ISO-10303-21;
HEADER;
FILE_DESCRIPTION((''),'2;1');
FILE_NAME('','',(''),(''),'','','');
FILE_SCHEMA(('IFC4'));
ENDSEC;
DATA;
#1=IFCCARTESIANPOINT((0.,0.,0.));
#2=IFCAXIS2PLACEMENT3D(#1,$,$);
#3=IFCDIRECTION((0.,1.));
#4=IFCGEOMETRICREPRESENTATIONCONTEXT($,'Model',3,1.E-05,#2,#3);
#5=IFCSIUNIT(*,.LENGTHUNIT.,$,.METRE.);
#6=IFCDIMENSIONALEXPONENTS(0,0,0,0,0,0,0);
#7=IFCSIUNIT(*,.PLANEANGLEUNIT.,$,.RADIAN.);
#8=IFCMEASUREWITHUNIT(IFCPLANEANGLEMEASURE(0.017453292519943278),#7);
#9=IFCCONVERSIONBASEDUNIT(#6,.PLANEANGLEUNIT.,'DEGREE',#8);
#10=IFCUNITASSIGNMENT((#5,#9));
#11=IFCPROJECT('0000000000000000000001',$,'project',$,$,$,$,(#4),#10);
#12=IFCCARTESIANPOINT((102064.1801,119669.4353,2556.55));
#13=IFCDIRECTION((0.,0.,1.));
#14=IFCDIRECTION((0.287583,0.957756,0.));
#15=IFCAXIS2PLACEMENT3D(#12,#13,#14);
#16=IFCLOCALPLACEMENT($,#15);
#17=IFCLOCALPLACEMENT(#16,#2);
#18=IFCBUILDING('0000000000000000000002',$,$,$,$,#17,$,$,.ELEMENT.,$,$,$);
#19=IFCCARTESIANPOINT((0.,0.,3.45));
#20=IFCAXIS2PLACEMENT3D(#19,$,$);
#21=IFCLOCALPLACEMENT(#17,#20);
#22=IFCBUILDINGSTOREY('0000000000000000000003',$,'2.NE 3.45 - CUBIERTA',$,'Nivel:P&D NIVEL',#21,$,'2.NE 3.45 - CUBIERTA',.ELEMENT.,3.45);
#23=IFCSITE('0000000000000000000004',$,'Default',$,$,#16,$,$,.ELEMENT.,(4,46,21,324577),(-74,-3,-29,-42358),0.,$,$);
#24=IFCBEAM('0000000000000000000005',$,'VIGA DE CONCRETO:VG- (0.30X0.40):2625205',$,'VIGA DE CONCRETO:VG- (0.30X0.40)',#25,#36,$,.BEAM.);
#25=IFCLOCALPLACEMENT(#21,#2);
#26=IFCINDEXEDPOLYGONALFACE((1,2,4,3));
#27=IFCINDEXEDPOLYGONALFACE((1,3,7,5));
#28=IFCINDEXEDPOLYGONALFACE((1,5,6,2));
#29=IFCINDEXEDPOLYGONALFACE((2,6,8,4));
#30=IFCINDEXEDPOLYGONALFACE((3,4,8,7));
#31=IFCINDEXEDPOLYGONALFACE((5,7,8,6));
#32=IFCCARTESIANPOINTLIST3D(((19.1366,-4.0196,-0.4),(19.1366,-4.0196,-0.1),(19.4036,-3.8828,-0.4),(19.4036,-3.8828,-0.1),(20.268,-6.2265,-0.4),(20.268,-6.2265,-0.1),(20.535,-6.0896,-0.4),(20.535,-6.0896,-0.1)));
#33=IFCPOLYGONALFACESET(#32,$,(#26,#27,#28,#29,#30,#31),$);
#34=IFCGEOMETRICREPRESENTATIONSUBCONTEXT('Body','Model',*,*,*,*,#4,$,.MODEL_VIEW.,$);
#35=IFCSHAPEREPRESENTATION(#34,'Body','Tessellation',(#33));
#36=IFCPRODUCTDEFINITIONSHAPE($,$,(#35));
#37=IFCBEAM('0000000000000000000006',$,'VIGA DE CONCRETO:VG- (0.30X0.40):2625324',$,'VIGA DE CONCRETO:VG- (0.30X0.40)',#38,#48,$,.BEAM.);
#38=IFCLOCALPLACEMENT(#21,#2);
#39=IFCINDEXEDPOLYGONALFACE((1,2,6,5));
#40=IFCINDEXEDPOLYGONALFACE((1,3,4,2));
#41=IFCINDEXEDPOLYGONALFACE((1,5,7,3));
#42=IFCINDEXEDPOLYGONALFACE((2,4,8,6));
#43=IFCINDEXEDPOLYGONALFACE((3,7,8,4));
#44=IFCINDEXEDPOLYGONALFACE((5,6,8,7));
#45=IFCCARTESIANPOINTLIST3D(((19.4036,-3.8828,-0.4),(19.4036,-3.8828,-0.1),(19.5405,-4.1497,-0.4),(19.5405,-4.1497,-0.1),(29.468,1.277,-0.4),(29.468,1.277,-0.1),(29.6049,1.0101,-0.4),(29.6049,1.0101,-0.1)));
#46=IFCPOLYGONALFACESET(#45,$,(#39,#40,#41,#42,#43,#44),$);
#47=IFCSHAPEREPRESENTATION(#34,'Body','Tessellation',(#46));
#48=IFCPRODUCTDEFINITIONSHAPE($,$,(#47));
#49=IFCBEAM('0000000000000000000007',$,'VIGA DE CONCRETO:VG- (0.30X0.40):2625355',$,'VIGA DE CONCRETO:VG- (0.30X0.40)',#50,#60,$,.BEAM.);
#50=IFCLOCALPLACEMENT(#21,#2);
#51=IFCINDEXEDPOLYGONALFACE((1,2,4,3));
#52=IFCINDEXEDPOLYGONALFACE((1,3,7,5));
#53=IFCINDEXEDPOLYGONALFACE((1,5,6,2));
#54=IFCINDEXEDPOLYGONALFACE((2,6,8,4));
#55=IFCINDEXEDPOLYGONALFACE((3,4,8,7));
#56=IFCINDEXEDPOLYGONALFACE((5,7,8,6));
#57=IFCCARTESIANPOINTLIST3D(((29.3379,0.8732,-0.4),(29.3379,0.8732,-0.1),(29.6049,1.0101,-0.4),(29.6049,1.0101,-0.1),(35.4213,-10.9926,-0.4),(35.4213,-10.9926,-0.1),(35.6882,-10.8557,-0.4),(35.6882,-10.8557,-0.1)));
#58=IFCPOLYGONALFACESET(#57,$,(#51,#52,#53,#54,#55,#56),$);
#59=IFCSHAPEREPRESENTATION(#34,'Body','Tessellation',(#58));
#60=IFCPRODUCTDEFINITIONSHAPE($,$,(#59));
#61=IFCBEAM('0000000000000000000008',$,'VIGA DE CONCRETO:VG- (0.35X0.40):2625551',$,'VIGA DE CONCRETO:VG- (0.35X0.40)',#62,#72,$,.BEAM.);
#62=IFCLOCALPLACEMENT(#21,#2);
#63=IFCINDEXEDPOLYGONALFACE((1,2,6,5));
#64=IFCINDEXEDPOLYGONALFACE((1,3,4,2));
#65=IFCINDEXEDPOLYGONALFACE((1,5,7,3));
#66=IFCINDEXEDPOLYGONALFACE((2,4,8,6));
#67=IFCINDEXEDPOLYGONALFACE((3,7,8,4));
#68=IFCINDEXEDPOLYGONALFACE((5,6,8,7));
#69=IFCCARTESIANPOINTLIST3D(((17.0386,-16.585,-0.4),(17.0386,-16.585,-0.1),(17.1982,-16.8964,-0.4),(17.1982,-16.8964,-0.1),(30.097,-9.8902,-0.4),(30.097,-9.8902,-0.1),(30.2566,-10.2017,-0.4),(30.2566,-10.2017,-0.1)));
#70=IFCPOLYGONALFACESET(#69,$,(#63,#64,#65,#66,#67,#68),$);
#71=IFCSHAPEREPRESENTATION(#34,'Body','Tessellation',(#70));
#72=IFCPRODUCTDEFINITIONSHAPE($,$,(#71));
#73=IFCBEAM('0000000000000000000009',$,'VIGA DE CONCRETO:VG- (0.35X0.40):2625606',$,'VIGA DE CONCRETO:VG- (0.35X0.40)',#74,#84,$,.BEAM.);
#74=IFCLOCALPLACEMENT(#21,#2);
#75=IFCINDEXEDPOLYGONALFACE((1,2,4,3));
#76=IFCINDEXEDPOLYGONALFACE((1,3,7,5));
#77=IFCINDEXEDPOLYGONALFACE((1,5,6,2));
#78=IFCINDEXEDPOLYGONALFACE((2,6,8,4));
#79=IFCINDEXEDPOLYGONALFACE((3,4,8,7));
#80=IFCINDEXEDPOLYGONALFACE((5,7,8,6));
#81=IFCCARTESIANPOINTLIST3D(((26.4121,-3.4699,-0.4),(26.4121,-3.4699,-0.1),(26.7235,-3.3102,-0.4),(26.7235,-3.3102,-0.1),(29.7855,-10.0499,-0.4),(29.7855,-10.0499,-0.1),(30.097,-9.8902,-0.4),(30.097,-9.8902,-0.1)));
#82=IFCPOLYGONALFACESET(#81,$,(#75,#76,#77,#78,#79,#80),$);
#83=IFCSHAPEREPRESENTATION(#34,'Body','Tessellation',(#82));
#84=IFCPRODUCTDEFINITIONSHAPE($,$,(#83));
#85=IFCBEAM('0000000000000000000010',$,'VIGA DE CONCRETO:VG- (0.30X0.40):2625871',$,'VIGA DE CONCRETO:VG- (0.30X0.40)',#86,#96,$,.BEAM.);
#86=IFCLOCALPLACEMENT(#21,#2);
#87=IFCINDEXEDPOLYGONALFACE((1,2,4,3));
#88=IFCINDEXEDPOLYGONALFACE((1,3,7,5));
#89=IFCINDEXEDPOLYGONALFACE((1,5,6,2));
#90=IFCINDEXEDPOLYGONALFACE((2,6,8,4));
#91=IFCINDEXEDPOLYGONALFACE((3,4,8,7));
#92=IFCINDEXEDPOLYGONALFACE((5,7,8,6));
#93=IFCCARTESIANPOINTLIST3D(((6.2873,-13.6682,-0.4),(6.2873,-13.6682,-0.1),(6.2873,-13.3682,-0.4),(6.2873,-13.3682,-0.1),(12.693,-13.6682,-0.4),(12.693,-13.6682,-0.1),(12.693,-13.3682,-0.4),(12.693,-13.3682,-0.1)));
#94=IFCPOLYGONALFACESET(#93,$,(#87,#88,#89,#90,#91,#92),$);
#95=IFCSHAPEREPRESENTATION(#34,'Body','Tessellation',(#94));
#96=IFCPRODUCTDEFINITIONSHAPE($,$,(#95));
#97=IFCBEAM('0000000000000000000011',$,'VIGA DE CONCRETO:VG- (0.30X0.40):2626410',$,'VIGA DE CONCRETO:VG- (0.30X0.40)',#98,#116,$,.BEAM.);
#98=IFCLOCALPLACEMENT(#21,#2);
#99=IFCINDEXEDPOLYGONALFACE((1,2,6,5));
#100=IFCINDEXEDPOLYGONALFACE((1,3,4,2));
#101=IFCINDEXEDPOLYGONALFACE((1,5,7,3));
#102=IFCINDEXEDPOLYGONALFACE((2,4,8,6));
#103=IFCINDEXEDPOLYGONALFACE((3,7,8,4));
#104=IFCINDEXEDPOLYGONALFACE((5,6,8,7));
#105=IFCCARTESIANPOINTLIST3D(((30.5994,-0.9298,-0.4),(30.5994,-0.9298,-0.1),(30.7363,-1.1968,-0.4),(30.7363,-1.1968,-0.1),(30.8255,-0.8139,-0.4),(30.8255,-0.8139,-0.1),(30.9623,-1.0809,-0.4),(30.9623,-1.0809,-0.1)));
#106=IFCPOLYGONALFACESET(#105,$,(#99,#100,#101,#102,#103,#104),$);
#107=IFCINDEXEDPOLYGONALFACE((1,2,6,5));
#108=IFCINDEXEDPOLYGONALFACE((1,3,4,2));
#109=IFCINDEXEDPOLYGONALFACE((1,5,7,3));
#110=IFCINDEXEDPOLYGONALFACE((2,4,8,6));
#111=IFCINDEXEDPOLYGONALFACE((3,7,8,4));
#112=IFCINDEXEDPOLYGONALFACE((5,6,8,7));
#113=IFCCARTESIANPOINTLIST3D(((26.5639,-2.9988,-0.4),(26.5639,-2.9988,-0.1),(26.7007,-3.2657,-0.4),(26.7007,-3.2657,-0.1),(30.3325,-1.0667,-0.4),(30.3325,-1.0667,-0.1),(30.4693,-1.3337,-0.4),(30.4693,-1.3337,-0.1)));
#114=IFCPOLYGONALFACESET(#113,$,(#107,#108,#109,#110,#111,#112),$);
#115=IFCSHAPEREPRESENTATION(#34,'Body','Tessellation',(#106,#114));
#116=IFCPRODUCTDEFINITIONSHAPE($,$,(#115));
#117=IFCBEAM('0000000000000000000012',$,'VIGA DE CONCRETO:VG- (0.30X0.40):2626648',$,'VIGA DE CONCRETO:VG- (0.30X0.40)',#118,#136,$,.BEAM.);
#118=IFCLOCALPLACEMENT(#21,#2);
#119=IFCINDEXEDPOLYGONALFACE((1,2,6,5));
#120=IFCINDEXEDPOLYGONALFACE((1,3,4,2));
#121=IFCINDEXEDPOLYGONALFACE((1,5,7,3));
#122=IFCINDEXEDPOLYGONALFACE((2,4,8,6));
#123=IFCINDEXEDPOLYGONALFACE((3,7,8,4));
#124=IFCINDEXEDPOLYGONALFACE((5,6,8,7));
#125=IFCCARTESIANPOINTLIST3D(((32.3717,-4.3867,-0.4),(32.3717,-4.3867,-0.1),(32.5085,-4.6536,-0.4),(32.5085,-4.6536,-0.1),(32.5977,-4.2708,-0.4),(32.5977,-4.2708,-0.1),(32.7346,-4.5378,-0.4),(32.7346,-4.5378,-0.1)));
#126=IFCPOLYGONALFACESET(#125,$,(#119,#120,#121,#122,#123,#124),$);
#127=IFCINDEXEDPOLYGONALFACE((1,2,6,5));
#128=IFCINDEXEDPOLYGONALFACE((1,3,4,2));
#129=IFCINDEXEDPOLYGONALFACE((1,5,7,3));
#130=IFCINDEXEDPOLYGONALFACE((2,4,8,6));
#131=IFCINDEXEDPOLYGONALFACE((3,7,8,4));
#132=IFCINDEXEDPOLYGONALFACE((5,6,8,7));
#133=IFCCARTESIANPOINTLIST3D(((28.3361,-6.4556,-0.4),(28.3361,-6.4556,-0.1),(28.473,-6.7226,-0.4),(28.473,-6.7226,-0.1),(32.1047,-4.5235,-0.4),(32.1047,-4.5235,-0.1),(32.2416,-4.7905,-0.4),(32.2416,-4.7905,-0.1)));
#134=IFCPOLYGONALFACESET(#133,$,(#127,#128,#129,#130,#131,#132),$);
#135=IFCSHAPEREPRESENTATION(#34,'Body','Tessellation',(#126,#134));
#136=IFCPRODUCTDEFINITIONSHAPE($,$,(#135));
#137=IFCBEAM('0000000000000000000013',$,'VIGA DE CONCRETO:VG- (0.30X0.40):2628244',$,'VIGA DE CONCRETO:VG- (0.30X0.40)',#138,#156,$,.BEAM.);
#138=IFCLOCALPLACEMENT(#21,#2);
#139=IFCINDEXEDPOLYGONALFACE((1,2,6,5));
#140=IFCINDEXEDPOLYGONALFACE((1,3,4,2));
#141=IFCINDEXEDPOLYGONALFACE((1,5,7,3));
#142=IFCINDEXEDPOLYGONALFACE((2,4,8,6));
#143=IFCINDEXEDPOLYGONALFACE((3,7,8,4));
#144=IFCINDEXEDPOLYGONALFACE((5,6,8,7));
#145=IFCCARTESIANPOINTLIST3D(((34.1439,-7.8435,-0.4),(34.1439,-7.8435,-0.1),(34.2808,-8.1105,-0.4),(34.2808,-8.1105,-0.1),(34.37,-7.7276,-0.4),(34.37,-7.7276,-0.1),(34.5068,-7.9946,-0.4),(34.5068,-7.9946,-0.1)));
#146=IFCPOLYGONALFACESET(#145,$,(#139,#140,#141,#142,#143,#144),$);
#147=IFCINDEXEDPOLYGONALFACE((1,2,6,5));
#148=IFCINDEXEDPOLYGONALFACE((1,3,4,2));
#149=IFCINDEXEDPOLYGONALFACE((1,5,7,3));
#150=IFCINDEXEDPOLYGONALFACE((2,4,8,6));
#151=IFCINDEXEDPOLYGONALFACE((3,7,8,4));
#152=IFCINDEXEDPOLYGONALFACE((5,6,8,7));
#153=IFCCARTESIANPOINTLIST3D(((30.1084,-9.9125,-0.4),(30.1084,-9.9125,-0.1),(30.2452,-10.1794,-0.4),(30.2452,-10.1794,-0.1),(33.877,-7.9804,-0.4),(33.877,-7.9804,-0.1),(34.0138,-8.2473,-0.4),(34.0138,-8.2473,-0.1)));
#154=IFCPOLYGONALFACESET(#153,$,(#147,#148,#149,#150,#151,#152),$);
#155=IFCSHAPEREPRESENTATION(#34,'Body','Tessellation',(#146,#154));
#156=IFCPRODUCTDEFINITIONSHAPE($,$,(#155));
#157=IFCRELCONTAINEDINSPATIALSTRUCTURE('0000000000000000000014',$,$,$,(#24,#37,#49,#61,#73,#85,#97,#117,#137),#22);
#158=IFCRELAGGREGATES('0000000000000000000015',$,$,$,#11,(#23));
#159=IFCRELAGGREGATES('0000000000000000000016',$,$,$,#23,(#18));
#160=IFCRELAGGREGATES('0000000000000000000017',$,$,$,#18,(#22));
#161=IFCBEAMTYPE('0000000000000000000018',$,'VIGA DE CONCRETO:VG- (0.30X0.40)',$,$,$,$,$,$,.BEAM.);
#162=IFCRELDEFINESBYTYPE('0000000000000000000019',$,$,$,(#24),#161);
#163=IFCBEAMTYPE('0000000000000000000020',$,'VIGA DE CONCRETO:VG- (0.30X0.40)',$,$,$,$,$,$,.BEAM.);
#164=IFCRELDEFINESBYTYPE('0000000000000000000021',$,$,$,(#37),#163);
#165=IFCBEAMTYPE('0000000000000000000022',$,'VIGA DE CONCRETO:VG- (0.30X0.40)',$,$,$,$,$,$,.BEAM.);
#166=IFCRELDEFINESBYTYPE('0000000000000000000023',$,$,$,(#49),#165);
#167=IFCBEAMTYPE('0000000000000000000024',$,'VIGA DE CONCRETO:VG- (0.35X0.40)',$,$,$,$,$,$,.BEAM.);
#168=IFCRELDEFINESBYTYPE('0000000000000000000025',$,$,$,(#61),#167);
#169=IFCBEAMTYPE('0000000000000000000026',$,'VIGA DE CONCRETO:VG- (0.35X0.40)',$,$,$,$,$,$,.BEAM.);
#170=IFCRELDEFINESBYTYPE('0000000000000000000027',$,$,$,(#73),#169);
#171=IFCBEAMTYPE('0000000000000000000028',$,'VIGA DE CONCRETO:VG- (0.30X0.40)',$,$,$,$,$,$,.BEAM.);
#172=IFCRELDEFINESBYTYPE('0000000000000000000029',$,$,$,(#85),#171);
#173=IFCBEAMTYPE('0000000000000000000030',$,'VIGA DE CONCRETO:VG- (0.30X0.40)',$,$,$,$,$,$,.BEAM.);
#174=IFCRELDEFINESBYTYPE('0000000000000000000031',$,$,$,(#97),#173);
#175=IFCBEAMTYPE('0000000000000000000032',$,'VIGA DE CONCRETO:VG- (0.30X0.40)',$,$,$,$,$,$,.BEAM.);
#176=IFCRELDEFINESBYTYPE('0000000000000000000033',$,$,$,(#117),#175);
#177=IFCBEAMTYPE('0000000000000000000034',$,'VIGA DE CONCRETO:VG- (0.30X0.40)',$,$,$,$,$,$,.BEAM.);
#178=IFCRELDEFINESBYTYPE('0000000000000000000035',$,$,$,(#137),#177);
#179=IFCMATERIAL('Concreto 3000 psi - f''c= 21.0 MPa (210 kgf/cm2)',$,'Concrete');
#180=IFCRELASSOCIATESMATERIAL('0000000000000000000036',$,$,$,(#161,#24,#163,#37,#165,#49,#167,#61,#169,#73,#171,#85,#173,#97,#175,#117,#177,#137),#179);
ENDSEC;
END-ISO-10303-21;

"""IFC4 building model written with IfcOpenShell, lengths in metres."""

from ifc_helpers import new_model, entity, si_unit, converted_unit, direction, frame, origin, place, context, subcontext, project, spatial, indexed_curve, outline, extrude, source, transform, mapped, material, type_object, type_shapes, element, save


model = new_model("IFC4")

# Units and contexts
model_context = context("Model", 3, precision=1e-05, world=origin(), true_north=direction((0.0, 1.0)))
body_context = subcontext(model_context, "Body", "Model", "MODEL_VIEW")
ifc_project = project(units=[si_unit("LENGTHUNIT", "METRE"), converted_unit("PLANEANGLEUNIT", "DEGREE", entity("IfcPlaneAngleMeasure", 0.017453292519943278), si_unit("PLANEANGLEUNIT", "RADIAN"), dimensions=[0, 0, 0, 0, 0, 0, 0])], contexts=[model_context])

# Site, building, storey
site_placement = place(None, frame((102064.1801, 119669.4353, 2556.55), z_axis=(0.0, 0.0, 1.0), x_axis=(0.287583, 0.957756, 0.0)))
site = spatial("IfcSite", under=ifc_project, at=site_placement, Name="Default", CompositionType="ELEMENT", RefLatitude=(4, 46, 21, 324577), RefLongitude=(-74, -3, -29, -42358), RefElevation=0.0)
building_placement = place(site_placement, origin())
building = spatial("IfcBuilding", under=site, at=building_placement, CompositionType="ELEMENT")
storey_placement = place(building_placement, frame((0.0, 0.0, 3.45)))
storey = spatial("IfcBuildingStorey", under=building, at=storey_placement, Name="2.NE 3.45 - CUBIERTA", ObjectType="Nivel:P&D NIVEL", LongName="2.NE 3.45 - CUBIERTA", CompositionType="ELEMENT", Elevation=3.45)

# Beams
ifc_material_1 = material(Name="Concreto 3000 psi - f'c= 21.0 MPa (210 kgf/cm2)", Category="Concrete")
beam_type_1 = type_object("IfcBeamType", Name="VIGA DE CONCRETO:VG- (0.30X0.40)", PredefinedType="BEAM", material=ifc_material_1)
shared_shape_1 = source(origin(), body_context, "Body", "SweptSolid", [
    extrude(outline(indexed_curve([(-0.15, -0.15), (0.15, -0.15), (0.15, 0.15), (-0.15, 0.15), (-0.15, -0.15)], self_intersect=False)), frame((20.4015, -6.1581, 3.2), z_axis=(-0.456217, 0.889869, 0.0), x_axis=(0.0, 0.0, 1.0)), (0.0, 0.0, 1.0), 2.48),
])
type_shapes(beam_type_1, [shared_shape_1])
beam_1_placement = place(storey_placement, frame((0.0, 0.0, -3.45)))
element("IfcBeam", 1, at=beam_1_placement, inside=storey, type_object=beam_type_1, material=ifc_material_1, Name="VIGA DE CONCRETO:VG- (0.30X0.40):2625205", ObjectType="VIGA DE CONCRETO:VG- (0.30X0.40)", PredefinedType="BEAM", context=body_context, shape_type="MappedRepresentation", body=[
    mapped(shared_shape_1, transform((0.0, 0.0, 0.0), scale=1.0)),
])
beam_type_2 = type_object("IfcBeamType", Name="VIGA DE CONCRETO:VG- (0.30X0.40)", PredefinedType="BEAM", material=ifc_material_1)
shared_shape_2 = source(origin(), body_context, "Body", "SweptSolid", [
    extrude(outline(indexed_curve([(-0.15, -0.15), (0.15, -0.15), (0.15, 0.15), (-0.15, 0.15), (-0.15, -0.15)], self_intersect=False)), frame((19.472, -4.0162, 3.2), z_axis=(0.889869, 0.456217, 0.0), x_axis=(0.0, 0.0, 1.0)), (0.0, 0.0, 1.0), 11.31),
])
type_shapes(beam_type_2, [shared_shape_2])
beam_2_placement = place(storey_placement, frame((0.0, 0.0, -3.45)))
element("IfcBeam", 2, at=beam_2_placement, inside=storey, type_object=beam_type_2, material=ifc_material_1, Name="VIGA DE CONCRETO:VG- (0.30X0.40):2625324", ObjectType="VIGA DE CONCRETO:VG- (0.30X0.40)", PredefinedType="BEAM", context=body_context, shape_type="MappedRepresentation", body=[
    mapped(shared_shape_2, transform((0.0, 0.0, 0.0), scale=1.0)),
])
beam_type_3 = type_object("IfcBeamType", Name="VIGA DE CONCRETO:VG- (0.30X0.40)", PredefinedType="BEAM", material=ifc_material_1)
shared_shape_3 = source(origin(), body_context, "Body", "SweptSolid", [
    extrude(outline(indexed_curve([(-0.15, -0.15), (0.15, -0.15), (0.15, 0.15), (-0.15, 0.15), (-0.15, -0.15)], self_intersect=False)), frame((29.4714, 0.9417, 3.2), z_axis=(0.456217, -0.889869, 0.0), x_axis=(0.0, 0.0, -1.0)), (0.0, 0.0, 1.0), 13.3343),
])
type_shapes(beam_type_3, [shared_shape_3])
beam_3_placement = place(storey_placement, frame((0.0, 0.0, -3.45)))
element("IfcBeam", 3, at=beam_3_placement, inside=storey, type_object=beam_type_3, material=ifc_material_1, Name="VIGA DE CONCRETO:VG- (0.30X0.40):2625355", ObjectType="VIGA DE CONCRETO:VG- (0.30X0.40)", PredefinedType="BEAM", context=body_context, shape_type="MappedRepresentation", body=[
    mapped(shared_shape_3, transform((0.0, 0.0, 0.0), scale=1.0)),
])
beam_type_4 = type_object("IfcBeamType", Name="VIGA DE CONCRETO:VG- (0.35X0.40)", PredefinedType="BEAM", material=ifc_material_1)
shared_shape_4 = source(origin(), body_context, "Body", "SweptSolid", [
    extrude(outline(indexed_curve([(-0.15, -0.175), (0.15, -0.175), (0.15, 0.175), (-0.15, 0.175), (-0.15, -0.175)], self_intersect=False)), frame((17.1184, -16.7407, 3.2), z_axis=(0.889869, 0.456217, 0.0), x_axis=(0.0, 0.0, 1.0)), (0.0, 0.0, 1.0), 14.6745),
])
type_shapes(beam_type_4, [shared_shape_4])
beam_4_placement = place(storey_placement, frame((0.0, 0.0, -3.45)))
element("IfcBeam", 4, at=beam_4_placement, inside=storey, type_object=beam_type_4, material=ifc_material_1, Name="VIGA DE CONCRETO:VG- (0.35X0.40):2625551", ObjectType="VIGA DE CONCRETO:VG- (0.35X0.40)", PredefinedType="BEAM", context=body_context, shape_type="MappedRepresentation", body=[
    mapped(shared_shape_4, transform((0.0, 0.0, 0.0), scale=1.0)),
])
beam_type_5 = type_object("IfcBeamType", Name="VIGA DE CONCRETO:VG- (0.35X0.40)", PredefinedType="BEAM", material=ifc_material_1)
shared_shape_5 = source(origin(), body_context, "Body", "SweptSolid", [
    extrude(outline(indexed_curve([(-0.15, -0.175), (0.15, -0.175), (0.15, 0.175), (-0.15, 0.175), (-0.15, -0.175)], self_intersect=False)), frame((29.9412, -9.97, 3.2), z_axis=(-0.456217, 0.889869, 0.0), x_axis=(0.0, 0.0, 1.0)), (0.0, 0.0, 1.0), 7.3943),
])
type_shapes(beam_type_5, [shared_shape_5])
beam_5_placement = place(storey_placement, frame((0.0, 0.0, -3.45)))
element("IfcBeam", 5, at=beam_5_placement, inside=storey, type_object=beam_type_5, material=ifc_material_1, Name="VIGA DE CONCRETO:VG- (0.35X0.40):2625606", ObjectType="VIGA DE CONCRETO:VG- (0.35X0.40)", PredefinedType="BEAM", context=body_context, shape_type="MappedRepresentation", body=[
    mapped(shared_shape_5, transform((0.0, 0.0, 0.0), scale=1.0)),
])
beam_type_6 = type_object("IfcBeamType", Name="VIGA DE CONCRETO:VG- (0.30X0.40)", PredefinedType="BEAM", material=ifc_material_1)
shared_shape_6 = source(origin(), body_context, "Body", "SweptSolid", [
    extrude(outline(indexed_curve([(-0.15, -0.15), (0.15, -0.15), (0.15, 0.15), (-0.15, 0.15), (-0.15, -0.15)], self_intersect=False)), frame((6.2873, -13.5182, 3.2), z_axis=(1.0, 0.0, 0.0), x_axis=(0.0, 0.0, -1.0)), (0.0, 0.0, 1.0), 6.4058),
])
type_shapes(beam_type_6, [shared_shape_6])
beam_6_placement = place(storey_placement, frame((0.0, 0.0, -3.45)))
element("IfcBeam", 6, at=beam_6_placement, inside=storey, type_object=beam_type_6, material=ifc_material_1, Name="VIGA DE CONCRETO:VG- (0.30X0.40):2625871", ObjectType="VIGA DE CONCRETO:VG- (0.30X0.40)", PredefinedType="BEAM", context=body_context, shape_type="MappedRepresentation", body=[
    mapped(shared_shape_6, transform((0.0, 0.0, 0.0), scale=1.0)),
])
beam_type_7 = type_object("IfcBeamType", Name="VIGA DE CONCRETO:VG- (0.30X0.40)", PredefinedType="BEAM", material=ifc_material_1)
shared_shape_7 = source(origin(), body_context, "Body", "SweptSolid", [
    extrude(outline(indexed_curve([(-0.15, -0.15), (0.15, -0.15), (0.15, 0.15), (-0.15, 0.15), (-0.15, -0.15)], self_intersect=False)), frame((30.6679, -1.0633, 3.2), z_axis=(0.889869, 0.456217, 0.0), x_axis=(0.0, 0.0, 1.0)), (0.0, 0.0, 1.0), 0.254),
    extrude(outline(indexed_curve([(-0.15, -0.15), (0.15, -0.15), (0.15, 0.15), (-0.15, 0.15), (-0.15, -0.15)], self_intersect=False)), frame((26.6323, -3.1322, 3.2), z_axis=(0.889869, 0.456217, 0.0), x_axis=(0.0, 0.0, 1.0)), (0.0, 0.0, 1.0), 4.235),
])
type_shapes(beam_type_7, [shared_shape_7])
beam_7_placement = place(storey_placement, frame((0.0, 0.0, -3.45)))
element("IfcBeam", 7, at=beam_7_placement, inside=storey, type_object=beam_type_7, material=ifc_material_1, Name="VIGA DE CONCRETO:VG- (0.30X0.40):2626410", ObjectType="VIGA DE CONCRETO:VG- (0.30X0.40)", PredefinedType="BEAM", context=body_context, shape_type="MappedRepresentation", body=[
    mapped(shared_shape_7, transform((0.0, 0.0, 0.0), scale=1.0)),
])
beam_type_8 = type_object("IfcBeamType", Name="VIGA DE CONCRETO:VG- (0.30X0.40)", PredefinedType="BEAM", material=ifc_material_1)
shared_shape_8 = source(origin(), body_context, "Body", "SweptSolid", [
    extrude(outline(indexed_curve([(-0.15, -0.15), (0.15, -0.15), (0.15, 0.15), (-0.15, 0.15), (-0.15, -0.15)], self_intersect=False)), frame((32.4401, -4.5202, 3.2), z_axis=(0.889869, 0.456217, 0.0), x_axis=(0.0, 0.0, 1.0)), (0.0, 0.0, 1.0), 0.254),
    extrude(outline(indexed_curve([(-0.15, -0.15), (0.15, -0.15), (0.15, 0.15), (-0.15, 0.15), (-0.15, -0.15)], self_intersect=False)), frame((28.4046, -6.5891, 3.2), z_axis=(0.889869, 0.456217, 0.0), x_axis=(0.0, 0.0, 1.0)), (0.0, 0.0, 1.0), 4.235),
])
type_shapes(beam_type_8, [shared_shape_8])
beam_8_placement = place(storey_placement, frame((0.0, 0.0, -3.45)))
element("IfcBeam", 8, at=beam_8_placement, inside=storey, type_object=beam_type_8, material=ifc_material_1, Name="VIGA DE CONCRETO:VG- (0.30X0.40):2626648", ObjectType="VIGA DE CONCRETO:VG- (0.30X0.40)", PredefinedType="BEAM", context=body_context, shape_type="MappedRepresentation", body=[
    mapped(shared_shape_8, transform((0.0, 0.0, 0.0), scale=1.0)),
])
beam_type_9 = type_object("IfcBeamType", Name="VIGA DE CONCRETO:VG- (0.30X0.40)", PredefinedType="BEAM", material=ifc_material_1)
shared_shape_9 = source(origin(), body_context, "Body", "SweptSolid", [
    extrude(outline(indexed_curve([(-0.15, -0.15), (0.15, -0.15), (0.15, 0.15), (-0.15, 0.15), (-0.15, -0.15)], self_intersect=False)), frame((34.2124, -7.977, 3.2), z_axis=(0.889869, 0.456217, 0.0), x_axis=(0.0, 0.0, 1.0)), (0.0, 0.0, 1.0), 0.254),
    extrude(outline(indexed_curve([(-0.15, -0.15), (0.15, -0.15), (0.15, 0.15), (-0.15, 0.15), (-0.15, -0.15)], self_intersect=False)), frame((30.1768, -10.0459, 3.2), z_axis=(0.889869, 0.456217, 0.0), x_axis=(0.0, 0.0, 1.0)), (0.0, 0.0, 1.0), 4.235),
])
type_shapes(beam_type_9, [shared_shape_9])
beam_9_placement = place(storey_placement, frame((0.0, 0.0, -3.45)))
element("IfcBeam", 9, at=beam_9_placement, inside=storey, type_object=beam_type_9, material=ifc_material_1, Name="VIGA DE CONCRETO:VG- (0.30X0.40):2628244", ObjectType="VIGA DE CONCRETO:VG- (0.30X0.40)", PredefinedType="BEAM", context=body_context, shape_type="MappedRepresentation", body=[
    mapped(shared_shape_9, transform((0.0, 0.0, 0.0), scale=1.0)),
])

save(model, "model.ifc")
